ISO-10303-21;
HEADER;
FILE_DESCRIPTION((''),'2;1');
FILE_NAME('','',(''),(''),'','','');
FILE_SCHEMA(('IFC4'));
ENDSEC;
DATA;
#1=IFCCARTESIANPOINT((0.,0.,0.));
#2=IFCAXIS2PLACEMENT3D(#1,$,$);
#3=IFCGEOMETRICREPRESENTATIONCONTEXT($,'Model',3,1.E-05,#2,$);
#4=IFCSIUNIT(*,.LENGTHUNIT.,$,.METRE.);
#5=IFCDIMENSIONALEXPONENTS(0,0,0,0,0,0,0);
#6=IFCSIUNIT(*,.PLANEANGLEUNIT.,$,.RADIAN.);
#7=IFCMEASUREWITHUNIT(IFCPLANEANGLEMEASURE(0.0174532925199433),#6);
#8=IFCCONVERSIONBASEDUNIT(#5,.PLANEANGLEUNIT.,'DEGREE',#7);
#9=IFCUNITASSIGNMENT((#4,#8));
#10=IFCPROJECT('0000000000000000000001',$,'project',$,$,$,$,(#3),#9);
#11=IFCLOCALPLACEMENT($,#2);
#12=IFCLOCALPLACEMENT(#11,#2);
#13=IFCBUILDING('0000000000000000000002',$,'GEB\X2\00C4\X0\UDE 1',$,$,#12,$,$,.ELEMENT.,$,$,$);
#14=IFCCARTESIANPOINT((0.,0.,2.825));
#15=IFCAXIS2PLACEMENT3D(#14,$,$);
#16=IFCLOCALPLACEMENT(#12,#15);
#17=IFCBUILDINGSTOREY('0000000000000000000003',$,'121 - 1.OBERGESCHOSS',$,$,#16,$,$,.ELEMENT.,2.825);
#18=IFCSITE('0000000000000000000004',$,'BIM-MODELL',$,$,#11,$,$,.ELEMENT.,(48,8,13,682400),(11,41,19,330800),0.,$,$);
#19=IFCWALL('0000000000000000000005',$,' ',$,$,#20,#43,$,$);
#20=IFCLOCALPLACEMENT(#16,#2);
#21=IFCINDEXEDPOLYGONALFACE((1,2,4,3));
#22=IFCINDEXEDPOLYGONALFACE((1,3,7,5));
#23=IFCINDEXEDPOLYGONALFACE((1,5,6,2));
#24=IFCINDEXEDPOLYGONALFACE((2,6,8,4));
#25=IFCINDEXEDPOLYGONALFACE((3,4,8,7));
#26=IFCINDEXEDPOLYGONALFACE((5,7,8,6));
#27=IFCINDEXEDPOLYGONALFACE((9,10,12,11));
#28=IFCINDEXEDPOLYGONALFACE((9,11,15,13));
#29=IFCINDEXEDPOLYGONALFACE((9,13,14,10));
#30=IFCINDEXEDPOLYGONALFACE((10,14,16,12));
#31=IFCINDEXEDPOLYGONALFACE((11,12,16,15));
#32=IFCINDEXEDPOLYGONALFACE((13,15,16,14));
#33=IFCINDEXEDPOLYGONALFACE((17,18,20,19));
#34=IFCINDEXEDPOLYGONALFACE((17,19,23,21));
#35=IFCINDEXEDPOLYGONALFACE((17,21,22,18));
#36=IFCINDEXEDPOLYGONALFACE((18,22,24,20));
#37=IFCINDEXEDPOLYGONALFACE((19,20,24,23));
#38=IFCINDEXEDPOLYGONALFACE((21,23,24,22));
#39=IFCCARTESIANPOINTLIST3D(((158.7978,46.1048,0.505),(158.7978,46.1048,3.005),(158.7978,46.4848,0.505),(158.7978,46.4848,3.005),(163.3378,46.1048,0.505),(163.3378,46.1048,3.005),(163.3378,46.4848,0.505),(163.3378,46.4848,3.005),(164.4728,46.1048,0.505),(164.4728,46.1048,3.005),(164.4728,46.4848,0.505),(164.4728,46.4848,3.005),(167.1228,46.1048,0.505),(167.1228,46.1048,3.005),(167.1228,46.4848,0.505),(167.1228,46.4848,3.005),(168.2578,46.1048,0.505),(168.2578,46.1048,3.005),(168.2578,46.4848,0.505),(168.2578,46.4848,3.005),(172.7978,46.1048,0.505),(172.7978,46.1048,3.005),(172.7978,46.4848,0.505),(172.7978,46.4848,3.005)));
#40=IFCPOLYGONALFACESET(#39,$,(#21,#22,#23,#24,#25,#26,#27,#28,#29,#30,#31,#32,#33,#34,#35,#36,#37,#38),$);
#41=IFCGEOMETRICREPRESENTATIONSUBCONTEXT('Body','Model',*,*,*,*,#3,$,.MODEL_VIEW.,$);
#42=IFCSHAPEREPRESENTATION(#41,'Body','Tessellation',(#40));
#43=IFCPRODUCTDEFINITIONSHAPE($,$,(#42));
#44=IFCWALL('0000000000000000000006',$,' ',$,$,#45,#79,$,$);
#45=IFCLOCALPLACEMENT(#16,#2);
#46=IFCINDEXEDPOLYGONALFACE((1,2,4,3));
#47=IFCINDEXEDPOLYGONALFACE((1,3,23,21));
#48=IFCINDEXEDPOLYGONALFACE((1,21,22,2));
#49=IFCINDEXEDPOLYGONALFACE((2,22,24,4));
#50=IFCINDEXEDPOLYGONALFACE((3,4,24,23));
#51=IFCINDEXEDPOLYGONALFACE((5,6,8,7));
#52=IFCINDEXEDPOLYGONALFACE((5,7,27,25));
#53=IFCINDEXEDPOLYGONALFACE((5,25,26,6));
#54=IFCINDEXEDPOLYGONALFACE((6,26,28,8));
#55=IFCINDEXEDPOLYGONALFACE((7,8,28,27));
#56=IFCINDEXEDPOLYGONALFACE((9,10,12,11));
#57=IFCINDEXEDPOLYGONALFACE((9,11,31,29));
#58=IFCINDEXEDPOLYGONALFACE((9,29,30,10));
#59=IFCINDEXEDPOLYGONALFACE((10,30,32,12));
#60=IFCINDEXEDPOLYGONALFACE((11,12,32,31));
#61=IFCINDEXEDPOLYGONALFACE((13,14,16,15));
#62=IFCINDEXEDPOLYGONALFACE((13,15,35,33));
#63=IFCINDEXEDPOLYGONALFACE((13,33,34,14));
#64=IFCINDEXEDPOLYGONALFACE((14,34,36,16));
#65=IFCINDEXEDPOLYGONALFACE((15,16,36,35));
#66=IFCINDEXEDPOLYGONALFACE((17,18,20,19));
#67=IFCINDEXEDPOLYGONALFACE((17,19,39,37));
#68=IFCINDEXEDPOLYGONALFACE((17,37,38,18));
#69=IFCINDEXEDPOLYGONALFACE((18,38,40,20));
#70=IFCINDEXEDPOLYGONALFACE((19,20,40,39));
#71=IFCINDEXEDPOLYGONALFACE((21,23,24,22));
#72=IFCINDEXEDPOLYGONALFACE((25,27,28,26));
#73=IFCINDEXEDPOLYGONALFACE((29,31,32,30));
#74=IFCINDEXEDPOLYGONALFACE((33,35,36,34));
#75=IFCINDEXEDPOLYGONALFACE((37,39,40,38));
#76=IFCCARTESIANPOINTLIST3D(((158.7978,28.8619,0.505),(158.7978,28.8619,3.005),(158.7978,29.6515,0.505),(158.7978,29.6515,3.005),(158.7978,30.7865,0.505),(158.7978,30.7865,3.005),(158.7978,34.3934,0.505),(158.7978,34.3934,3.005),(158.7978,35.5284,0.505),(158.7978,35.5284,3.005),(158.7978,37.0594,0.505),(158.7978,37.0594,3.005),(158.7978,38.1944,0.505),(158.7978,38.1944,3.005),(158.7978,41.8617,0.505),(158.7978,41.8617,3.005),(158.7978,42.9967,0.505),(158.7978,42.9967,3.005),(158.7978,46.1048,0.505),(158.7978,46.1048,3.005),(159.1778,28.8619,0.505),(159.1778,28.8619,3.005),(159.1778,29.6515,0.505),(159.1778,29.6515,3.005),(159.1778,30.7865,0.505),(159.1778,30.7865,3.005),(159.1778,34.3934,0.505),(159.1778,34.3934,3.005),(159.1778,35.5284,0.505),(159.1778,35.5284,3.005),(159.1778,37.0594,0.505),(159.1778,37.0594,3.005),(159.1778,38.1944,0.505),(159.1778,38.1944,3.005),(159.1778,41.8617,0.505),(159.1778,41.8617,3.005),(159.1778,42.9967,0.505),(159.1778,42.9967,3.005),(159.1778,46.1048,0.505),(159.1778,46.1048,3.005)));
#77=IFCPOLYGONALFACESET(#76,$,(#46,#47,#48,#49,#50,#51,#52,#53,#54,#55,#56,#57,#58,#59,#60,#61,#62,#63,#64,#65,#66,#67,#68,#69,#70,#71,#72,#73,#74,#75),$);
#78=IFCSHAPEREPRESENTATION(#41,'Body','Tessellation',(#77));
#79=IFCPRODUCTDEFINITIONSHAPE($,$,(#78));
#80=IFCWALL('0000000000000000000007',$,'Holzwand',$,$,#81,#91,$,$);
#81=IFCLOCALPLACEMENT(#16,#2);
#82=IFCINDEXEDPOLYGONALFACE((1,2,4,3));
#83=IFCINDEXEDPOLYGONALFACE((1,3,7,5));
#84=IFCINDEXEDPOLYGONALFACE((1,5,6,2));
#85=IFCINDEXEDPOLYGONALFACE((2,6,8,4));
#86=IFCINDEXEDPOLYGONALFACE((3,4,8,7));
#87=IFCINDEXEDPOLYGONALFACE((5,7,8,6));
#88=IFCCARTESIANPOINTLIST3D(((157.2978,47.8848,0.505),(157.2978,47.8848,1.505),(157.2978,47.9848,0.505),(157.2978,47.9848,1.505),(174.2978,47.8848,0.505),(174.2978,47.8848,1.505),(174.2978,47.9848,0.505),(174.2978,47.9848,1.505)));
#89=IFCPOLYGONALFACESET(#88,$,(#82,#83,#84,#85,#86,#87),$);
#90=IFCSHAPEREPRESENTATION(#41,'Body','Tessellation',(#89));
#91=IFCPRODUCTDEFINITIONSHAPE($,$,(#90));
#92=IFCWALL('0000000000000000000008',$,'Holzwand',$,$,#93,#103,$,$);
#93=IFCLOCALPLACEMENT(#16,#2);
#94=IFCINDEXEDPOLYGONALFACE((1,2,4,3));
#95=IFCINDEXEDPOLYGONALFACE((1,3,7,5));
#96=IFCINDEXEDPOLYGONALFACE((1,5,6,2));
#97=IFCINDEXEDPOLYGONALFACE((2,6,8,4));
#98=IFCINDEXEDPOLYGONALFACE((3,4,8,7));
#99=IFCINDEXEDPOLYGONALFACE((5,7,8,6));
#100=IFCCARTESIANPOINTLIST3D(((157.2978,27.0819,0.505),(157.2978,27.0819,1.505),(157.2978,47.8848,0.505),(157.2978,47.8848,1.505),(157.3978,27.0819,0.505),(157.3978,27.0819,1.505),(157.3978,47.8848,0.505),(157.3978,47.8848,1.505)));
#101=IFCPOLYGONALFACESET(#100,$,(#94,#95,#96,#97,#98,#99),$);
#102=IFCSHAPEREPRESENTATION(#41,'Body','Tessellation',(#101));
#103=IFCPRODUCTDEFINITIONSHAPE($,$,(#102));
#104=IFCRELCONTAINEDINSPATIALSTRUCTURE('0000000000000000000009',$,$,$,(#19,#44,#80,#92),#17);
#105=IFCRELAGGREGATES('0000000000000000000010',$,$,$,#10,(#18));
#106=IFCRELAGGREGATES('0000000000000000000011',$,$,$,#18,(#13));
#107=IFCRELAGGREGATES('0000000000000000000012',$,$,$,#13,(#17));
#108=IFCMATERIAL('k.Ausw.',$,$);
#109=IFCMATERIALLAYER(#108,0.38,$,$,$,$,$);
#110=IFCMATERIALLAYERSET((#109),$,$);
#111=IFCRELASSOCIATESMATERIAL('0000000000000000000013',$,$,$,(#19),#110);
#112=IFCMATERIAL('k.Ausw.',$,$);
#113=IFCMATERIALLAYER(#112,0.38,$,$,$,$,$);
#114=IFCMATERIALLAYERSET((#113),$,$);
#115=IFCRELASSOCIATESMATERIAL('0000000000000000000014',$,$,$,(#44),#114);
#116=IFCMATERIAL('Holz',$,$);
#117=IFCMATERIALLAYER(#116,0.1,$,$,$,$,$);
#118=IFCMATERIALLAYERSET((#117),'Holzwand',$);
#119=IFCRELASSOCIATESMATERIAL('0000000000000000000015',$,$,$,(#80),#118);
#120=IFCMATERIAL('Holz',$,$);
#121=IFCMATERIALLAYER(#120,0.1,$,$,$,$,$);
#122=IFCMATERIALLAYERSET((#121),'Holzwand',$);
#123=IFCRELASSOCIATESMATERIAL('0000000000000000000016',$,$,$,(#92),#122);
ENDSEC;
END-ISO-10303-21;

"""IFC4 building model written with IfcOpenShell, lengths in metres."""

from ifc_helpers import new_model, entity, si_unit, converted_unit, frame, frame_2d, origin, origin_with_axes, place, context, subcontext, project, spatial, polyline, rectangle, outline, extrude, material, layer, layer_set, layer_usage, element, save


model = new_model("IFC4")

# Units and contexts
model_context = context("Model", 3, precision=1e-05, world=origin())
body_context = subcontext(model_context, "Body", "Model", "MODEL_VIEW")
ifc_project = project(units=[si_unit("LENGTHUNIT", "METRE"), converted_unit("PLANEANGLEUNIT", "DEGREE", entity("IfcPlaneAngleMeasure", 0.0174532925199433), si_unit("PLANEANGLEUNIT", "RADIAN"), dimensions=[0, 0, 0, 0, 0, 0, 0])], contexts=[model_context])

# Site, building, storey
site_placement = place(None, origin())
site = spatial("IfcSite", under=ifc_project, at=site_placement, Name="BIM-MODELL", CompositionType="ELEMENT", RefLatitude=(48, 8, 13, 682400), RefLongitude=(11, 41, 19, 330800), RefElevation=0.0)
building_placement = place(site_placement, origin())
building = spatial("IfcBuilding", under=site, at=building_placement, Name="GEBÄUDE 1", CompositionType="ELEMENT")
storey_placement = place(building_placement, frame((0.0, 0.0, 2.825)))
storey = spatial("IfcBuildingStorey", under=building, at=storey_placement, Name="121 - 1.OBERGESCHOSS", CompositionType="ELEMENT", Elevation=2.825)

# Walls, openings
ifc_material_1 = material(Name="k.Ausw.")
ifc_layer_1 = layer(ifc_material_1, 0.38)
ifc_layer_set_1 = layer_set([ifc_layer_1])
ifc_layer_usage_1 = layer_usage(ifc_layer_set_1, "AXIS2", "POSITIVE", 0.0)
wall_1_placement = place(storey_placement, frame((172.7978, 46.4848, 0.505), z_axis=(0.0, 0.0, 1.0), x_axis=(-1.0, 0.0, 0.0)))
wall_1 = element("IfcWall", 1, at=wall_1_placement, inside=storey, material=ifc_layer_usage_1, Name=" ", context=body_context, shape_type="SweptSolid", body=[
    extrude(rectangle(XDim=14.0, YDim=0.38, at=frame_2d((7.0, 0.19), x_axis=(1.0, 0.0))), origin_with_axes(), (0.0, 0.0, 1.0), 2.5),
])
opening_1_placement = place(wall_1_placement, frame((5.675, 0.38, 0.0), z_axis=(0.0, -1.0, 0.0), x_axis=(0.0, 0.0, 1.0)))
element("IfcOpeningElement", 2, at=opening_1_placement, cuts=wall_1, ObjectType="Opening", context=body_context, shape_type="SweptSolid", body=[
    extrude(outline(polyline([(0.0, 1.135), (2.5, 1.135), (2.5, 0.0), (0.0, 0.0), (0.0, 1.135)])), origin_with_axes(), (0.0, 0.0, 1.0), 0.38),
])
opening_2_placement = place(wall_1_placement, frame((9.46, 0.38, 0.0), z_axis=(0.0, -1.0, 0.0), x_axis=(0.0, 0.0, 1.0)))
element("IfcOpeningElement", 3, at=opening_2_placement, cuts=wall_1, ObjectType="Opening", context=body_context, shape_type="SweptSolid", body=[
    extrude(outline(polyline([(0.0, 1.135), (2.5, 1.135), (2.5, 0.0), (0.0, 0.0), (0.0, 1.135)])), origin_with_axes(), (0.0, 0.0, 1.0), 0.38),
])
ifc_material_2 = material(Name="k.Ausw.")
ifc_layer_2 = layer(ifc_material_2, 0.38)
ifc_layer_set_2 = layer_set([ifc_layer_2])
ifc_layer_usage_2 = layer_usage(ifc_layer_set_2, "AXIS2", "POSITIVE", 0.0)
wall_2_placement = place(storey_placement, frame((158.7978, 46.1048, 0.505), z_axis=(0.0, 0.0, 1.0), x_axis=(0.0, -1.0, 0.0)))
wall_2 = element("IfcWall", 4, at=wall_2_placement, inside=storey, material=ifc_layer_usage_2, Name=" ", context=body_context, shape_type="SweptSolid", body=[
    extrude(rectangle(XDim=17.2429, YDim=0.38, at=frame_2d((8.6214, 0.19), x_axis=(1.0, 0.0))), origin_with_axes(), (0.0, 0.0, 1.0), 2.5),
])
opening_3_placement = place(wall_2_placement, frame((4.2431, 0.38, 0.0), z_axis=(0.0, -1.0, 0.0), x_axis=(0.0, 0.0, 1.0)))
element("IfcOpeningElement", 5, at=opening_3_placement, cuts=wall_2, ObjectType="Opening", context=body_context, shape_type="SweptSolid", body=[
    extrude(outline(polyline([(0.0, 1.135), (2.5, 1.135), (2.5, 0.0), (0.0, 0.0), (0.0, 1.135)])), origin_with_axes(), (0.0, 0.0, 1.0), 0.38),
])
opening_4_placement = place(wall_2_placement, frame((9.0454, 0.38, 0.0), z_axis=(0.0, -1.0, 0.0), x_axis=(0.0, 0.0, 1.0)))
element("IfcOpeningElement", 6, at=opening_4_placement, cuts=wall_2, ObjectType="Opening", context=body_context, shape_type="SweptSolid", body=[
    extrude(outline(polyline([(0.0, 1.135), (2.5, 1.135), (2.5, 0.0), (0.0, 0.0), (0.0, 1.135)])), origin_with_axes(), (0.0, 0.0, 1.0), 0.38),
])
opening_5_placement = place(wall_2_placement, frame((11.7114, 0.38, 0.0), z_axis=(0.0, -1.0, 0.0), x_axis=(0.0, 0.0, 1.0)))
element("IfcOpeningElement", 7, at=opening_5_placement, cuts=wall_2, ObjectType="Opening", context=body_context, shape_type="SweptSolid", body=[
    extrude(outline(polyline([(0.0, 1.135), (2.5, 1.135), (2.5, 0.0), (0.0, 0.0), (0.0, 1.135)])), origin_with_axes(), (0.0, 0.0, 1.0), 0.38),
])
opening_6_placement = place(wall_2_placement, frame((16.4533, 0.38, 0.0), z_axis=(0.0, -1.0, 0.0), x_axis=(0.0, 0.0, 1.0)))
element("IfcOpeningElement", 8, at=opening_6_placement, cuts=wall_2, ObjectType="Opening", context=body_context, shape_type="SweptSolid", body=[
    extrude(outline(polyline([(0.0, 1.135), (2.5, 1.135), (2.5, 0.0), (0.0, 0.0), (0.0, 1.135)])), origin_with_axes(), (0.0, 0.0, 1.0), 0.38),
])

# Walls
ifc_material_3 = material(Name="Holz")
ifc_layer_3 = layer(ifc_material_3, 0.1)
ifc_layer_set_3 = layer_set([ifc_layer_3], Name="Holzwand")
ifc_layer_usage_3 = layer_usage(ifc_layer_set_3, "AXIS2", "POSITIVE", 0.0)
wall_3_placement = place(storey_placement, frame((174.2978, 47.9848, 0.505), z_axis=(0.0, 0.0, 1.0), x_axis=(-1.0, 0.0, 0.0)))
element("IfcWall", 9, at=wall_3_placement, inside=storey, material=ifc_layer_usage_3, Name="Holzwand", context=body_context, shape_type="SweptSolid", body=[
    extrude(rectangle(XDim=17.0, YDim=0.1, at=frame_2d((8.5, 0.05), x_axis=(1.0, 0.0))), origin_with_axes(), (0.0, 0.0, 1.0), 1.0),
])
ifc_material_4 = material(Name="Holz")
ifc_layer_4 = layer(ifc_material_4, 0.1)
ifc_layer_set_4 = layer_set([ifc_layer_4], Name="Holzwand")
ifc_layer_usage_4 = layer_usage(ifc_layer_set_4, "AXIS2", "POSITIVE", 0.0)
wall_4_placement = place(storey_placement, frame((157.2978, 47.8848, 0.505), z_axis=(0.0, 0.0, 1.0), x_axis=(0.0, -1.0, 0.0)))
element("IfcWall", 10, at=wall_4_placement, inside=storey, material=ifc_layer_usage_4, Name="Holzwand", context=body_context, shape_type="SweptSolid", body=[
    extrude(rectangle(XDim=20.8029, YDim=0.1, at=frame_2d((10.4014, 0.05), x_axis=(1.0, 0.0))), origin_with_axes(), (0.0, 0.0, 1.0), 1.0),
])

save(model, "model.ifc")
